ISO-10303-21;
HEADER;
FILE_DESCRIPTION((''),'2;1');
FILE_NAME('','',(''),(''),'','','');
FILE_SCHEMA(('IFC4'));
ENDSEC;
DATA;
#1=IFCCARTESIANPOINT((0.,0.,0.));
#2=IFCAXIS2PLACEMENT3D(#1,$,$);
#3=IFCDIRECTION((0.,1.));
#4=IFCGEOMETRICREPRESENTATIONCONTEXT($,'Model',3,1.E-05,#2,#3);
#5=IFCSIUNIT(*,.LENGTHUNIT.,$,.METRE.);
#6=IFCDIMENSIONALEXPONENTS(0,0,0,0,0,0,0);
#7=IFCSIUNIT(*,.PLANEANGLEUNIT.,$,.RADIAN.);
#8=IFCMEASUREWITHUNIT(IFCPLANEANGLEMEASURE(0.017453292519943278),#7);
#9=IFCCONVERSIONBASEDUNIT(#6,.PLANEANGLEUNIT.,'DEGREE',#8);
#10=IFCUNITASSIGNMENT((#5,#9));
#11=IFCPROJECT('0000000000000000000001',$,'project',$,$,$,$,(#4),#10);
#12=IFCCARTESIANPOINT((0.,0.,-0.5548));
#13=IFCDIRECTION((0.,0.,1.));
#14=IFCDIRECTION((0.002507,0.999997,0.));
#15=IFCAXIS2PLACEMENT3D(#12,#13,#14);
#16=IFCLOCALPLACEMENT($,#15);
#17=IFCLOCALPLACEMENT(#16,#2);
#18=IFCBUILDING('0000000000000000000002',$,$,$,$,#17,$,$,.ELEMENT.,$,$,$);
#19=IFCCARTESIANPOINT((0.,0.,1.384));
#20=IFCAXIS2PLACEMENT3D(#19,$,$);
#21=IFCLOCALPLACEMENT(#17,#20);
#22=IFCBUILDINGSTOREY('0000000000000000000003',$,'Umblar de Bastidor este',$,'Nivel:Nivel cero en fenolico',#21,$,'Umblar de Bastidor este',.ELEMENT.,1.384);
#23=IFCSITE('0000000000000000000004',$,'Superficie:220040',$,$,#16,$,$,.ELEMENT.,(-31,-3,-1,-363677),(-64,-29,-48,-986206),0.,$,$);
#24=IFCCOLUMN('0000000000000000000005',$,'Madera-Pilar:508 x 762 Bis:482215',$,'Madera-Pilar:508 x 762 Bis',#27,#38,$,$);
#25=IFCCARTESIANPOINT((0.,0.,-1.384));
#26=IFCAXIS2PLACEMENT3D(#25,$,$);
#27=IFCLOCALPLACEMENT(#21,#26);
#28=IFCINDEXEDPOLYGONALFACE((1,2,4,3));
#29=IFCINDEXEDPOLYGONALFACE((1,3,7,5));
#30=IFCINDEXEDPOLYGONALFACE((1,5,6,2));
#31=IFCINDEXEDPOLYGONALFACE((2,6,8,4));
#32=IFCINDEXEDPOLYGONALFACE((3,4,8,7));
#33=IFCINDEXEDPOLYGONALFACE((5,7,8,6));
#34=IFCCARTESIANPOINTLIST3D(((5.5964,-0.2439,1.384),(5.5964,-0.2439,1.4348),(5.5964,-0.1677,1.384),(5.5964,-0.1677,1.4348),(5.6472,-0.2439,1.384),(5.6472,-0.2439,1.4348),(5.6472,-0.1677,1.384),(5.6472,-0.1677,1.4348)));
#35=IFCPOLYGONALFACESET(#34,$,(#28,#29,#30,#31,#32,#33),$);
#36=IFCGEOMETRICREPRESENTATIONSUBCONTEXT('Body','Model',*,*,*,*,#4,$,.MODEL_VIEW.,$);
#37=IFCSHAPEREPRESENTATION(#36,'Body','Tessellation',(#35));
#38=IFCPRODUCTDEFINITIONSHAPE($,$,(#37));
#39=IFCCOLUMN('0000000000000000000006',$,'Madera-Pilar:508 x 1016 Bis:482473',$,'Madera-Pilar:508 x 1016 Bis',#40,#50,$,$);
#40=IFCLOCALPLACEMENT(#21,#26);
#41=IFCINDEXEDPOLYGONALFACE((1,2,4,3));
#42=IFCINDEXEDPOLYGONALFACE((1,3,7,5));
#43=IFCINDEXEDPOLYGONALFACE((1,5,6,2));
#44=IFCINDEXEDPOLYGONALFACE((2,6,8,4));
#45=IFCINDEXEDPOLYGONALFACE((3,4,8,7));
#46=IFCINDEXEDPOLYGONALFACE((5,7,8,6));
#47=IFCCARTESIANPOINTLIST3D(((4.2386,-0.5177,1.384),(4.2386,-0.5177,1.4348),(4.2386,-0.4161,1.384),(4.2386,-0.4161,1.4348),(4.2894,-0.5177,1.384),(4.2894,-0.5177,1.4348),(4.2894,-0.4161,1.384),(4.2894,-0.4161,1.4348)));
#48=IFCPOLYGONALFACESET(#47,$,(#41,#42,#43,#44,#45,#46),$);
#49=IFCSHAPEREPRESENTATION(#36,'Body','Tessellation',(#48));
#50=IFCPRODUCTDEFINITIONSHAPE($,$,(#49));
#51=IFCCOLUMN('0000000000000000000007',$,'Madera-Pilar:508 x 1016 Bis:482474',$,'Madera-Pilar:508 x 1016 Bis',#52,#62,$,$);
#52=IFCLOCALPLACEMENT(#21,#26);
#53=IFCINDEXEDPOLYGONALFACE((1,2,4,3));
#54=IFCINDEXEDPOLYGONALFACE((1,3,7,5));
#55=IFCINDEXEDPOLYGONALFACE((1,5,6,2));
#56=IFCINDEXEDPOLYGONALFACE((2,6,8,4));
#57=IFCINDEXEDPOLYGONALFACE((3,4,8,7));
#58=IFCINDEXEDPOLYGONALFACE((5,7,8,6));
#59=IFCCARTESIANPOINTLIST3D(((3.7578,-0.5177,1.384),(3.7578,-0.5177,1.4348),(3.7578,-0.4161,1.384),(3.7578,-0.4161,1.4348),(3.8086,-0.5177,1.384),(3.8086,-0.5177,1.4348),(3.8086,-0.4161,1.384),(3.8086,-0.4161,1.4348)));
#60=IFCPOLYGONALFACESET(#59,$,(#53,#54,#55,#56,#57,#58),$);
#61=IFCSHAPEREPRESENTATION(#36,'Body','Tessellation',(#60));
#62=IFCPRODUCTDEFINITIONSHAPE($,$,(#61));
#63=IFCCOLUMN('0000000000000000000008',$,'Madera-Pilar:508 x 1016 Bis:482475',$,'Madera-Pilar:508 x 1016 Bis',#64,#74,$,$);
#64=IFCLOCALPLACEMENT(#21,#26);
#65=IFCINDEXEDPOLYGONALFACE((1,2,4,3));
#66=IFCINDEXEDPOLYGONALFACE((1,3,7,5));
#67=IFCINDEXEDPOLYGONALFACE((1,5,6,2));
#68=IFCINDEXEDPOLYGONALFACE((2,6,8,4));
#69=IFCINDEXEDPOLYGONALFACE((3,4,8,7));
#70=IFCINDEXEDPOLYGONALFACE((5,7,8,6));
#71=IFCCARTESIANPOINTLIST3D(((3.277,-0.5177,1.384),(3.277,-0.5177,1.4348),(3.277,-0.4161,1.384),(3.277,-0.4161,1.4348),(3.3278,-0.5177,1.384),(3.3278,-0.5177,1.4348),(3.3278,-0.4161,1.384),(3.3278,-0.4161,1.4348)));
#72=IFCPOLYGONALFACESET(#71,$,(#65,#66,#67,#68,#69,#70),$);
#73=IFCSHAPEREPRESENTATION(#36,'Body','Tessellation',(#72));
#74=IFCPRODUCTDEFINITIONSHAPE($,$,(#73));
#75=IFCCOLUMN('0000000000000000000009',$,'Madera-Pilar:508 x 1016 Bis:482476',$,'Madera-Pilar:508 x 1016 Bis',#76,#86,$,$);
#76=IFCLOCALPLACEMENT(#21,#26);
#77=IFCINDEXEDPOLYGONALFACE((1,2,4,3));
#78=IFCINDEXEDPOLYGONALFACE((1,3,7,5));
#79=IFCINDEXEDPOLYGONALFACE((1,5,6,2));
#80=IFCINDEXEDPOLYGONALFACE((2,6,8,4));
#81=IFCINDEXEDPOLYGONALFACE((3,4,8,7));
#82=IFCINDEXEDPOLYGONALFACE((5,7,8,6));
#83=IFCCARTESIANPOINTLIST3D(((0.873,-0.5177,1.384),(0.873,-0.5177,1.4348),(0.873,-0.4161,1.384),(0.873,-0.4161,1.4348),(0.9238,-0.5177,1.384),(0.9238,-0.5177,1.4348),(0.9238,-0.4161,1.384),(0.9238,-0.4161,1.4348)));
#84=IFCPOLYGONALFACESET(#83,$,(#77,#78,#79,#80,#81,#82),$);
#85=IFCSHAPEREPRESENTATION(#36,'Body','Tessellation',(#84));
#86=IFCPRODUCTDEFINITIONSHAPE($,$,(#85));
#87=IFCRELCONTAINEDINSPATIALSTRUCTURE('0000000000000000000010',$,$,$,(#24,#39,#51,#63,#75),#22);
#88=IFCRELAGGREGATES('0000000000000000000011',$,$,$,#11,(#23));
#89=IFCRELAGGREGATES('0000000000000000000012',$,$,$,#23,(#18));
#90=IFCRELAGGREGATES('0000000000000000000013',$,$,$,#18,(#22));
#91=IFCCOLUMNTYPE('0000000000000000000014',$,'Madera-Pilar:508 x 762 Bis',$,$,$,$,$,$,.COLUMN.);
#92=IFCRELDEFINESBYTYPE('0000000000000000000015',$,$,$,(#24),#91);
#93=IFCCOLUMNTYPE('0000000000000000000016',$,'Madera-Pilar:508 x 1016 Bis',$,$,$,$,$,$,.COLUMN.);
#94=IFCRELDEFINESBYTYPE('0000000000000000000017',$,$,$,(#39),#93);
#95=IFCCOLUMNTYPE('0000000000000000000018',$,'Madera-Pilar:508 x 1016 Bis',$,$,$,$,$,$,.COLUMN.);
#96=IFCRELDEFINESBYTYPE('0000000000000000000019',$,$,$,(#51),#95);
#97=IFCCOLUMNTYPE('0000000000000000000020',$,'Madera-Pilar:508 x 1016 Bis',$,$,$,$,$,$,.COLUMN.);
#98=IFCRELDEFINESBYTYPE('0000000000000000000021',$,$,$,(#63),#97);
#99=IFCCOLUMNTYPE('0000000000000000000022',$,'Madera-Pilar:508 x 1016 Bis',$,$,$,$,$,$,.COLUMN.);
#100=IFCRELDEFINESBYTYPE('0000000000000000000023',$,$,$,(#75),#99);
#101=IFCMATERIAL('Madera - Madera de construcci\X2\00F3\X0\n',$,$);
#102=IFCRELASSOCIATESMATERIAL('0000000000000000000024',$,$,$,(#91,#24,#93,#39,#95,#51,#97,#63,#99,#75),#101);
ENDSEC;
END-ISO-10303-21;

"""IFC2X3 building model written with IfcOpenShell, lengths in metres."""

from ifc_helpers import new_model, entity, si_unit, converted_unit, direction, frame, frame_2d, origin, place, context, subcontext, project, spatial, rectangle, extrude, source, transform, mapped, material, type_object, type_shapes, element, save


model = new_model("IFC2X3")

# Units and contexts
model_context = context("Model", 3, precision=1e-05, world=origin(), true_north=direction((0.0, 1.0)))
body_context = subcontext(model_context, "Body", "Model", "MODEL_VIEW")
ifc_project = project(units=[si_unit("LENGTHUNIT", "METRE"), converted_unit("PLANEANGLEUNIT", "DEGREE", entity("IfcPlaneAngleMeasure", 0.017453292519943278), si_unit("PLANEANGLEUNIT", "RADIAN"), dimensions=[0, 0, 0, 0, 0, 0, 0])], contexts=[model_context])

# Site, building, storey
site_placement = place(None, frame((0.0, 0.0, -0.5548), z_axis=(0.0, 0.0, 1.0), x_axis=(0.002507, 0.999997, 0.0)))
site = spatial("IfcSite", under=ifc_project, at=site_placement, Name="Superficie:220040", CompositionType="ELEMENT", RefLatitude=(-31, -3, -1, -363677), RefLongitude=(-64, -29, -48, -986206), RefElevation=0.0)
building_placement = place(site_placement, origin())
building = spatial("IfcBuilding", under=site, at=building_placement, CompositionType="ELEMENT")
storey_placement = place(building_placement, frame((0.0, 0.0, 1.384)))
storey = spatial("IfcBuildingStorey", under=building, at=storey_placement, Name="Umblar de Bastidor este", ObjectType="Nivel:Nivel cero en fenolico", LongName="Umblar de Bastidor este", CompositionType="ELEMENT", Elevation=1.384)

# Columns
ifc_material = material(Name="Madera - Madera de construcción")
column_type_1 = type_object("IfcColumnType", Name="Madera-Pilar:508 x 762 Bis", PredefinedType="COLUMN", material=ifc_material)
shared_shape_1 = source(origin(), body_context, "Body", "SweptSolid", [
    extrude(rectangle(XDim=0.0508, YDim=0.0762, at=frame_2d((0.0, 0.0), x_axis=(1.0, 0.0))), frame((5.6218, -0.2058, 1.384), z_axis=(0.0, 0.0, 1.0), x_axis=(-1.0, 0.0, 0.0)), (0.0, 0.0, 1.0), 0.0508),
])
type_shapes(column_type_1, [shared_shape_1])
column_1_placement = place(storey_placement, frame((0.0, 0.0, -1.384)))
element("IfcColumn", 1, at=column_1_placement, inside=storey, type_object=column_type_1, material=ifc_material, Name="Madera-Pilar:508 x 762 Bis:482215", ObjectType="Madera-Pilar:508 x 762 Bis", context=body_context, shape_type="MappedRepresentation", body=[
    mapped(shared_shape_1, transform((0.0, 0.0, 0.0), scale=1.0)),
])
column_type_2 = type_object("IfcColumnType", Name="Madera-Pilar:508 x 1016 Bis", PredefinedType="COLUMN", material=ifc_material)
shared_shape_2 = source(origin(), body_context, "Body", "SweptSolid", [
    extrude(rectangle(XDim=0.0508, YDim=0.1016, at=frame_2d((0.0, 0.0), x_axis=(1.0, 0.0))), frame((4.264, -0.4669, 1.384)), (0.0, 0.0, 1.0), 0.0508),
])
type_shapes(column_type_2, [shared_shape_2])
column_2_placement = place(storey_placement, frame((0.0, 0.0, -1.384)))
element("IfcColumn", 2, at=column_2_placement, inside=storey, type_object=column_type_2, material=ifc_material, Name="Madera-Pilar:508 x 1016 Bis:482473", ObjectType="Madera-Pilar:508 x 1016 Bis", context=body_context, shape_type="MappedRepresentation", body=[
    mapped(shared_shape_2, transform((0.0, 0.0, 0.0), scale=1.0)),
])
column_type_3 = type_object("IfcColumnType", Name="Madera-Pilar:508 x 1016 Bis", PredefinedType="COLUMN", material=ifc_material)
shared_shape_3 = source(origin(), body_context, "Body", "SweptSolid", [
    extrude(rectangle(XDim=0.0508, YDim=0.1016, at=frame_2d((0.0, 0.0), x_axis=(1.0, 0.0))), frame((3.7832, -0.4669, 1.384)), (0.0, 0.0, 1.0), 0.0508),
])
type_shapes(column_type_3, [shared_shape_3])
column_3_placement = place(storey_placement, frame((0.0, 0.0, -1.384)))
element("IfcColumn", 3, at=column_3_placement, inside=storey, type_object=column_type_3, material=ifc_material, Name="Madera-Pilar:508 x 1016 Bis:482474", ObjectType="Madera-Pilar:508 x 1016 Bis", context=body_context, shape_type="MappedRepresentation", body=[
    mapped(shared_shape_3, transform((0.0, 0.0, 0.0), scale=1.0)),
])
column_type_4 = type_object("IfcColumnType", Name="Madera-Pilar:508 x 1016 Bis", PredefinedType="COLUMN", material=ifc_material)
shared_shape_4 = source(origin(), body_context, "Body", "SweptSolid", [
    extrude(rectangle(XDim=0.0508, YDim=0.1016, at=frame_2d((0.0, 0.0), x_axis=(1.0, 0.0))), frame((3.3024, -0.4669, 1.384)), (0.0, 0.0, 1.0), 0.0508),
])
type_shapes(column_type_4, [shared_shape_4])
column_4_placement = place(storey_placement, frame((0.0, 0.0, -1.384)))
element("IfcColumn", 4, at=column_4_placement, inside=storey, type_object=column_type_4, material=ifc_material, Name="Madera-Pilar:508 x 1016 Bis:482475", ObjectType="Madera-Pilar:508 x 1016 Bis", context=body_context, shape_type="MappedRepresentation", body=[
    mapped(shared_shape_4, transform((0.0, 0.0, 0.0), scale=1.0)),
])
column_type_5 = type_object("IfcColumnType", Name="Madera-Pilar:508 x 1016 Bis", PredefinedType="COLUMN", material=ifc_material)
shared_shape_5 = source(origin(), body_context, "Body", "SweptSolid", [
    extrude(rectangle(XDim=0.0508, YDim=0.1016, at=frame_2d((0.0, 0.0), x_axis=(1.0, 0.0))), frame((0.8984, -0.4669, 1.384)), (0.0, 0.0, 1.0), 0.0508),
])
type_shapes(column_type_5, [shared_shape_5])
column_5_placement = place(storey_placement, frame((0.0, 0.0, -1.384)))
element("IfcColumn", 5, at=column_5_placement, inside=storey, type_object=column_type_5, material=ifc_material, Name="Madera-Pilar:508 x 1016 Bis:482476", ObjectType="Madera-Pilar:508 x 1016 Bis", context=body_context, shape_type="MappedRepresentation", body=[
    mapped(shared_shape_5, transform((0.0, 0.0, 0.0), scale=1.0)),
])

save(model, "model.ifc")
